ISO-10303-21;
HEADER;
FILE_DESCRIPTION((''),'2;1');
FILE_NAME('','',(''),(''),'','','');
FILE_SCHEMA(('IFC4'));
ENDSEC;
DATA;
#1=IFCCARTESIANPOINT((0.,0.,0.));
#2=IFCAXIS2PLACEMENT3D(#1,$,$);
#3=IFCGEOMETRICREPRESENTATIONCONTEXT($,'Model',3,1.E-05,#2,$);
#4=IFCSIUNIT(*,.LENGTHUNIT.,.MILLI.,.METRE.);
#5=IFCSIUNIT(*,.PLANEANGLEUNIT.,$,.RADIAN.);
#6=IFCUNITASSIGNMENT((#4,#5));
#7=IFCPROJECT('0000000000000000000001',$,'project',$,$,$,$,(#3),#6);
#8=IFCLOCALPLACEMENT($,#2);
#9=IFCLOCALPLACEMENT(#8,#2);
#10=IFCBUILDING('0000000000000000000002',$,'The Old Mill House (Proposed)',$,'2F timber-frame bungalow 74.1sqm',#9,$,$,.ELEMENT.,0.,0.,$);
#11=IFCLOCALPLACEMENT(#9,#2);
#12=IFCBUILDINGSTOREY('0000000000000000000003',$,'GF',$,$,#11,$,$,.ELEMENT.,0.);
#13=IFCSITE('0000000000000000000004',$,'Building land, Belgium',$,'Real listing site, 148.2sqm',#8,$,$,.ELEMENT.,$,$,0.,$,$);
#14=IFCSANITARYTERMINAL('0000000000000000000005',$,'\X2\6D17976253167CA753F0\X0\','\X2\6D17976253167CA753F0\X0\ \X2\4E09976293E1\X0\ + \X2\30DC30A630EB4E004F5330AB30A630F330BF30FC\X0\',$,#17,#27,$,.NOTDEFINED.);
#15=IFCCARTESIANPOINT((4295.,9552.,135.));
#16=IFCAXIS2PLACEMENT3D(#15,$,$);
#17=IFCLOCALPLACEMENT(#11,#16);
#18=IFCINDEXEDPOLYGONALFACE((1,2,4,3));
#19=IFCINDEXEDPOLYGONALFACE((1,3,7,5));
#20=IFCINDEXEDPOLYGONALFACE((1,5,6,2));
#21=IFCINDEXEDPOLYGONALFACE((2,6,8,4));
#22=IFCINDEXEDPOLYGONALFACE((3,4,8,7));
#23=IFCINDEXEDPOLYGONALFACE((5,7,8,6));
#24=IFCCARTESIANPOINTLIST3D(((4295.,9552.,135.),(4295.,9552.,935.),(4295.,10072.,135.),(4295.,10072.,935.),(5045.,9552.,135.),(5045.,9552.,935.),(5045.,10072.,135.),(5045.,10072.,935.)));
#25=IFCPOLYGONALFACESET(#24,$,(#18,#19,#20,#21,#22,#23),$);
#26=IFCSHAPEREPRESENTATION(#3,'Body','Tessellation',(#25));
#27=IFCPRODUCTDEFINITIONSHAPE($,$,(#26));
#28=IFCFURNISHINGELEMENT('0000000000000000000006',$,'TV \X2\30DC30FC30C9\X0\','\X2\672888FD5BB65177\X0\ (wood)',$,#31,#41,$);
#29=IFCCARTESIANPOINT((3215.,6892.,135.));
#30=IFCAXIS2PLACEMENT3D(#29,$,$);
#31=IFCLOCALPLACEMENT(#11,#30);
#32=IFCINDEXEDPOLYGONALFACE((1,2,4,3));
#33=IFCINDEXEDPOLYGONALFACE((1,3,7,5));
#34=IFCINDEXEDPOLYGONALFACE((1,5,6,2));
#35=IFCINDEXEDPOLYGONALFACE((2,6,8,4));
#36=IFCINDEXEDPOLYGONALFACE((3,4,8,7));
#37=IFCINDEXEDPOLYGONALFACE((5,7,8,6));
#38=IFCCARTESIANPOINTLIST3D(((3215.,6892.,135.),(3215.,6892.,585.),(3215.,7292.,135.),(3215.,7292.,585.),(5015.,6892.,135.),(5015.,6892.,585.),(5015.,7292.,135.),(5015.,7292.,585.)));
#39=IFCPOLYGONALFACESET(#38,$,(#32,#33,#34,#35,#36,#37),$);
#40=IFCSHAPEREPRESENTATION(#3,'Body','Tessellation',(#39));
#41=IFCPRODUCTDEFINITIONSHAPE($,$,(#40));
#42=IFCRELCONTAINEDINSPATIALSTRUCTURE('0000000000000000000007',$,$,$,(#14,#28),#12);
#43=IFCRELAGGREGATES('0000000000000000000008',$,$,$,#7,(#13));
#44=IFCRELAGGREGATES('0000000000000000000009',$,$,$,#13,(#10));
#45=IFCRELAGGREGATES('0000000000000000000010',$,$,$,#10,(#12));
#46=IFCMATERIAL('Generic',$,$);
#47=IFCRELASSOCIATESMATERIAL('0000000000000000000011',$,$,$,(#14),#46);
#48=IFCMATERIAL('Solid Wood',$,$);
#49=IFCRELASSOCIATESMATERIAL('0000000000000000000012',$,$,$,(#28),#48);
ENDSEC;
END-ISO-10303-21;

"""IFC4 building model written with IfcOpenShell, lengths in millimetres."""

from ifc_helpers import new_model, si_unit, frame, frame_2d, origin, place, context, project, spatial, rectangle, extrude, material, element, save


model = new_model("IFC4")

# Units and contexts
model_context = context("Model", 3, precision=1e-05, world=origin())
ifc_project = project(units=[si_unit("LENGTHUNIT", "METRE", prefix="MILLI"), si_unit("PLANEANGLEUNIT", "RADIAN")], contexts=[model_context])

# Site, building, storey
site_placement = place(None, origin())
site = spatial("IfcSite", under=ifc_project, at=site_placement, Name="Building land, Belgium", ObjectType="Real listing site, 148.2sqm", CompositionType="ELEMENT", RefElevation=0.0)
building_placement = place(site_placement, origin())
building = spatial("IfcBuilding", under=site, at=building_placement, Name="The Old Mill House (Proposed)", ObjectType="2F timber-frame bungalow 74.1sqm", CompositionType="ELEMENT", ElevationOfRefHeight=0.0, ElevationOfTerrain=0.0)
storey_placement = place(building_placement, origin())
storey = spatial("IfcBuildingStorey", under=building, at=storey_placement, Name="GF", CompositionType="ELEMENT", Elevation=0.0)

# Shared definitions
ifc_material_1 = material(Name="Solid Wood")

# Shared definitions
ifc_material_2 = material(Name="Generic")

# Sanitary terminal
sanitary_terminal_1_placement = place(storey_placement, frame((4295.0, 9552.0, 135.0)))
element("IfcSanitaryTerminal", 1, at=sanitary_terminal_1_placement, inside=storey, material=ifc_material_2, Name="洗面化粧台", Description="洗面化粧台 三面鏡 + ボウル一体カウンター", PredefinedType="NOTDEFINED", context=model_context, shape_type="SweptSolid", body=[
    extrude(rectangle(XDim=750.0, YDim=520.0, at=frame_2d((375.0, 260.0))), frame((4295.0, 9552.0, 135.0)), (0.0, 0.0, 1.0), 800.0),
])

# Furnishing element
furnishing_placement = place(storey_placement, frame((3215.0, 6892.0, 135.0)))
element("IfcFurnishingElement", 2, at=furnishing_placement, inside=storey, material=ifc_material_1, Name="TV ボード", Description="木製家具 (wood)", context=model_context, shape_type="SweptSolid", body=[
    extrude(rectangle(XDim=1800.0, YDim=400.0, at=frame_2d((900.0, 200.0))), frame((3215.0, 6892.0, 135.0)), (0.0, 0.0, 1.0), 450.0),
])

save(model, "model.ifc")
